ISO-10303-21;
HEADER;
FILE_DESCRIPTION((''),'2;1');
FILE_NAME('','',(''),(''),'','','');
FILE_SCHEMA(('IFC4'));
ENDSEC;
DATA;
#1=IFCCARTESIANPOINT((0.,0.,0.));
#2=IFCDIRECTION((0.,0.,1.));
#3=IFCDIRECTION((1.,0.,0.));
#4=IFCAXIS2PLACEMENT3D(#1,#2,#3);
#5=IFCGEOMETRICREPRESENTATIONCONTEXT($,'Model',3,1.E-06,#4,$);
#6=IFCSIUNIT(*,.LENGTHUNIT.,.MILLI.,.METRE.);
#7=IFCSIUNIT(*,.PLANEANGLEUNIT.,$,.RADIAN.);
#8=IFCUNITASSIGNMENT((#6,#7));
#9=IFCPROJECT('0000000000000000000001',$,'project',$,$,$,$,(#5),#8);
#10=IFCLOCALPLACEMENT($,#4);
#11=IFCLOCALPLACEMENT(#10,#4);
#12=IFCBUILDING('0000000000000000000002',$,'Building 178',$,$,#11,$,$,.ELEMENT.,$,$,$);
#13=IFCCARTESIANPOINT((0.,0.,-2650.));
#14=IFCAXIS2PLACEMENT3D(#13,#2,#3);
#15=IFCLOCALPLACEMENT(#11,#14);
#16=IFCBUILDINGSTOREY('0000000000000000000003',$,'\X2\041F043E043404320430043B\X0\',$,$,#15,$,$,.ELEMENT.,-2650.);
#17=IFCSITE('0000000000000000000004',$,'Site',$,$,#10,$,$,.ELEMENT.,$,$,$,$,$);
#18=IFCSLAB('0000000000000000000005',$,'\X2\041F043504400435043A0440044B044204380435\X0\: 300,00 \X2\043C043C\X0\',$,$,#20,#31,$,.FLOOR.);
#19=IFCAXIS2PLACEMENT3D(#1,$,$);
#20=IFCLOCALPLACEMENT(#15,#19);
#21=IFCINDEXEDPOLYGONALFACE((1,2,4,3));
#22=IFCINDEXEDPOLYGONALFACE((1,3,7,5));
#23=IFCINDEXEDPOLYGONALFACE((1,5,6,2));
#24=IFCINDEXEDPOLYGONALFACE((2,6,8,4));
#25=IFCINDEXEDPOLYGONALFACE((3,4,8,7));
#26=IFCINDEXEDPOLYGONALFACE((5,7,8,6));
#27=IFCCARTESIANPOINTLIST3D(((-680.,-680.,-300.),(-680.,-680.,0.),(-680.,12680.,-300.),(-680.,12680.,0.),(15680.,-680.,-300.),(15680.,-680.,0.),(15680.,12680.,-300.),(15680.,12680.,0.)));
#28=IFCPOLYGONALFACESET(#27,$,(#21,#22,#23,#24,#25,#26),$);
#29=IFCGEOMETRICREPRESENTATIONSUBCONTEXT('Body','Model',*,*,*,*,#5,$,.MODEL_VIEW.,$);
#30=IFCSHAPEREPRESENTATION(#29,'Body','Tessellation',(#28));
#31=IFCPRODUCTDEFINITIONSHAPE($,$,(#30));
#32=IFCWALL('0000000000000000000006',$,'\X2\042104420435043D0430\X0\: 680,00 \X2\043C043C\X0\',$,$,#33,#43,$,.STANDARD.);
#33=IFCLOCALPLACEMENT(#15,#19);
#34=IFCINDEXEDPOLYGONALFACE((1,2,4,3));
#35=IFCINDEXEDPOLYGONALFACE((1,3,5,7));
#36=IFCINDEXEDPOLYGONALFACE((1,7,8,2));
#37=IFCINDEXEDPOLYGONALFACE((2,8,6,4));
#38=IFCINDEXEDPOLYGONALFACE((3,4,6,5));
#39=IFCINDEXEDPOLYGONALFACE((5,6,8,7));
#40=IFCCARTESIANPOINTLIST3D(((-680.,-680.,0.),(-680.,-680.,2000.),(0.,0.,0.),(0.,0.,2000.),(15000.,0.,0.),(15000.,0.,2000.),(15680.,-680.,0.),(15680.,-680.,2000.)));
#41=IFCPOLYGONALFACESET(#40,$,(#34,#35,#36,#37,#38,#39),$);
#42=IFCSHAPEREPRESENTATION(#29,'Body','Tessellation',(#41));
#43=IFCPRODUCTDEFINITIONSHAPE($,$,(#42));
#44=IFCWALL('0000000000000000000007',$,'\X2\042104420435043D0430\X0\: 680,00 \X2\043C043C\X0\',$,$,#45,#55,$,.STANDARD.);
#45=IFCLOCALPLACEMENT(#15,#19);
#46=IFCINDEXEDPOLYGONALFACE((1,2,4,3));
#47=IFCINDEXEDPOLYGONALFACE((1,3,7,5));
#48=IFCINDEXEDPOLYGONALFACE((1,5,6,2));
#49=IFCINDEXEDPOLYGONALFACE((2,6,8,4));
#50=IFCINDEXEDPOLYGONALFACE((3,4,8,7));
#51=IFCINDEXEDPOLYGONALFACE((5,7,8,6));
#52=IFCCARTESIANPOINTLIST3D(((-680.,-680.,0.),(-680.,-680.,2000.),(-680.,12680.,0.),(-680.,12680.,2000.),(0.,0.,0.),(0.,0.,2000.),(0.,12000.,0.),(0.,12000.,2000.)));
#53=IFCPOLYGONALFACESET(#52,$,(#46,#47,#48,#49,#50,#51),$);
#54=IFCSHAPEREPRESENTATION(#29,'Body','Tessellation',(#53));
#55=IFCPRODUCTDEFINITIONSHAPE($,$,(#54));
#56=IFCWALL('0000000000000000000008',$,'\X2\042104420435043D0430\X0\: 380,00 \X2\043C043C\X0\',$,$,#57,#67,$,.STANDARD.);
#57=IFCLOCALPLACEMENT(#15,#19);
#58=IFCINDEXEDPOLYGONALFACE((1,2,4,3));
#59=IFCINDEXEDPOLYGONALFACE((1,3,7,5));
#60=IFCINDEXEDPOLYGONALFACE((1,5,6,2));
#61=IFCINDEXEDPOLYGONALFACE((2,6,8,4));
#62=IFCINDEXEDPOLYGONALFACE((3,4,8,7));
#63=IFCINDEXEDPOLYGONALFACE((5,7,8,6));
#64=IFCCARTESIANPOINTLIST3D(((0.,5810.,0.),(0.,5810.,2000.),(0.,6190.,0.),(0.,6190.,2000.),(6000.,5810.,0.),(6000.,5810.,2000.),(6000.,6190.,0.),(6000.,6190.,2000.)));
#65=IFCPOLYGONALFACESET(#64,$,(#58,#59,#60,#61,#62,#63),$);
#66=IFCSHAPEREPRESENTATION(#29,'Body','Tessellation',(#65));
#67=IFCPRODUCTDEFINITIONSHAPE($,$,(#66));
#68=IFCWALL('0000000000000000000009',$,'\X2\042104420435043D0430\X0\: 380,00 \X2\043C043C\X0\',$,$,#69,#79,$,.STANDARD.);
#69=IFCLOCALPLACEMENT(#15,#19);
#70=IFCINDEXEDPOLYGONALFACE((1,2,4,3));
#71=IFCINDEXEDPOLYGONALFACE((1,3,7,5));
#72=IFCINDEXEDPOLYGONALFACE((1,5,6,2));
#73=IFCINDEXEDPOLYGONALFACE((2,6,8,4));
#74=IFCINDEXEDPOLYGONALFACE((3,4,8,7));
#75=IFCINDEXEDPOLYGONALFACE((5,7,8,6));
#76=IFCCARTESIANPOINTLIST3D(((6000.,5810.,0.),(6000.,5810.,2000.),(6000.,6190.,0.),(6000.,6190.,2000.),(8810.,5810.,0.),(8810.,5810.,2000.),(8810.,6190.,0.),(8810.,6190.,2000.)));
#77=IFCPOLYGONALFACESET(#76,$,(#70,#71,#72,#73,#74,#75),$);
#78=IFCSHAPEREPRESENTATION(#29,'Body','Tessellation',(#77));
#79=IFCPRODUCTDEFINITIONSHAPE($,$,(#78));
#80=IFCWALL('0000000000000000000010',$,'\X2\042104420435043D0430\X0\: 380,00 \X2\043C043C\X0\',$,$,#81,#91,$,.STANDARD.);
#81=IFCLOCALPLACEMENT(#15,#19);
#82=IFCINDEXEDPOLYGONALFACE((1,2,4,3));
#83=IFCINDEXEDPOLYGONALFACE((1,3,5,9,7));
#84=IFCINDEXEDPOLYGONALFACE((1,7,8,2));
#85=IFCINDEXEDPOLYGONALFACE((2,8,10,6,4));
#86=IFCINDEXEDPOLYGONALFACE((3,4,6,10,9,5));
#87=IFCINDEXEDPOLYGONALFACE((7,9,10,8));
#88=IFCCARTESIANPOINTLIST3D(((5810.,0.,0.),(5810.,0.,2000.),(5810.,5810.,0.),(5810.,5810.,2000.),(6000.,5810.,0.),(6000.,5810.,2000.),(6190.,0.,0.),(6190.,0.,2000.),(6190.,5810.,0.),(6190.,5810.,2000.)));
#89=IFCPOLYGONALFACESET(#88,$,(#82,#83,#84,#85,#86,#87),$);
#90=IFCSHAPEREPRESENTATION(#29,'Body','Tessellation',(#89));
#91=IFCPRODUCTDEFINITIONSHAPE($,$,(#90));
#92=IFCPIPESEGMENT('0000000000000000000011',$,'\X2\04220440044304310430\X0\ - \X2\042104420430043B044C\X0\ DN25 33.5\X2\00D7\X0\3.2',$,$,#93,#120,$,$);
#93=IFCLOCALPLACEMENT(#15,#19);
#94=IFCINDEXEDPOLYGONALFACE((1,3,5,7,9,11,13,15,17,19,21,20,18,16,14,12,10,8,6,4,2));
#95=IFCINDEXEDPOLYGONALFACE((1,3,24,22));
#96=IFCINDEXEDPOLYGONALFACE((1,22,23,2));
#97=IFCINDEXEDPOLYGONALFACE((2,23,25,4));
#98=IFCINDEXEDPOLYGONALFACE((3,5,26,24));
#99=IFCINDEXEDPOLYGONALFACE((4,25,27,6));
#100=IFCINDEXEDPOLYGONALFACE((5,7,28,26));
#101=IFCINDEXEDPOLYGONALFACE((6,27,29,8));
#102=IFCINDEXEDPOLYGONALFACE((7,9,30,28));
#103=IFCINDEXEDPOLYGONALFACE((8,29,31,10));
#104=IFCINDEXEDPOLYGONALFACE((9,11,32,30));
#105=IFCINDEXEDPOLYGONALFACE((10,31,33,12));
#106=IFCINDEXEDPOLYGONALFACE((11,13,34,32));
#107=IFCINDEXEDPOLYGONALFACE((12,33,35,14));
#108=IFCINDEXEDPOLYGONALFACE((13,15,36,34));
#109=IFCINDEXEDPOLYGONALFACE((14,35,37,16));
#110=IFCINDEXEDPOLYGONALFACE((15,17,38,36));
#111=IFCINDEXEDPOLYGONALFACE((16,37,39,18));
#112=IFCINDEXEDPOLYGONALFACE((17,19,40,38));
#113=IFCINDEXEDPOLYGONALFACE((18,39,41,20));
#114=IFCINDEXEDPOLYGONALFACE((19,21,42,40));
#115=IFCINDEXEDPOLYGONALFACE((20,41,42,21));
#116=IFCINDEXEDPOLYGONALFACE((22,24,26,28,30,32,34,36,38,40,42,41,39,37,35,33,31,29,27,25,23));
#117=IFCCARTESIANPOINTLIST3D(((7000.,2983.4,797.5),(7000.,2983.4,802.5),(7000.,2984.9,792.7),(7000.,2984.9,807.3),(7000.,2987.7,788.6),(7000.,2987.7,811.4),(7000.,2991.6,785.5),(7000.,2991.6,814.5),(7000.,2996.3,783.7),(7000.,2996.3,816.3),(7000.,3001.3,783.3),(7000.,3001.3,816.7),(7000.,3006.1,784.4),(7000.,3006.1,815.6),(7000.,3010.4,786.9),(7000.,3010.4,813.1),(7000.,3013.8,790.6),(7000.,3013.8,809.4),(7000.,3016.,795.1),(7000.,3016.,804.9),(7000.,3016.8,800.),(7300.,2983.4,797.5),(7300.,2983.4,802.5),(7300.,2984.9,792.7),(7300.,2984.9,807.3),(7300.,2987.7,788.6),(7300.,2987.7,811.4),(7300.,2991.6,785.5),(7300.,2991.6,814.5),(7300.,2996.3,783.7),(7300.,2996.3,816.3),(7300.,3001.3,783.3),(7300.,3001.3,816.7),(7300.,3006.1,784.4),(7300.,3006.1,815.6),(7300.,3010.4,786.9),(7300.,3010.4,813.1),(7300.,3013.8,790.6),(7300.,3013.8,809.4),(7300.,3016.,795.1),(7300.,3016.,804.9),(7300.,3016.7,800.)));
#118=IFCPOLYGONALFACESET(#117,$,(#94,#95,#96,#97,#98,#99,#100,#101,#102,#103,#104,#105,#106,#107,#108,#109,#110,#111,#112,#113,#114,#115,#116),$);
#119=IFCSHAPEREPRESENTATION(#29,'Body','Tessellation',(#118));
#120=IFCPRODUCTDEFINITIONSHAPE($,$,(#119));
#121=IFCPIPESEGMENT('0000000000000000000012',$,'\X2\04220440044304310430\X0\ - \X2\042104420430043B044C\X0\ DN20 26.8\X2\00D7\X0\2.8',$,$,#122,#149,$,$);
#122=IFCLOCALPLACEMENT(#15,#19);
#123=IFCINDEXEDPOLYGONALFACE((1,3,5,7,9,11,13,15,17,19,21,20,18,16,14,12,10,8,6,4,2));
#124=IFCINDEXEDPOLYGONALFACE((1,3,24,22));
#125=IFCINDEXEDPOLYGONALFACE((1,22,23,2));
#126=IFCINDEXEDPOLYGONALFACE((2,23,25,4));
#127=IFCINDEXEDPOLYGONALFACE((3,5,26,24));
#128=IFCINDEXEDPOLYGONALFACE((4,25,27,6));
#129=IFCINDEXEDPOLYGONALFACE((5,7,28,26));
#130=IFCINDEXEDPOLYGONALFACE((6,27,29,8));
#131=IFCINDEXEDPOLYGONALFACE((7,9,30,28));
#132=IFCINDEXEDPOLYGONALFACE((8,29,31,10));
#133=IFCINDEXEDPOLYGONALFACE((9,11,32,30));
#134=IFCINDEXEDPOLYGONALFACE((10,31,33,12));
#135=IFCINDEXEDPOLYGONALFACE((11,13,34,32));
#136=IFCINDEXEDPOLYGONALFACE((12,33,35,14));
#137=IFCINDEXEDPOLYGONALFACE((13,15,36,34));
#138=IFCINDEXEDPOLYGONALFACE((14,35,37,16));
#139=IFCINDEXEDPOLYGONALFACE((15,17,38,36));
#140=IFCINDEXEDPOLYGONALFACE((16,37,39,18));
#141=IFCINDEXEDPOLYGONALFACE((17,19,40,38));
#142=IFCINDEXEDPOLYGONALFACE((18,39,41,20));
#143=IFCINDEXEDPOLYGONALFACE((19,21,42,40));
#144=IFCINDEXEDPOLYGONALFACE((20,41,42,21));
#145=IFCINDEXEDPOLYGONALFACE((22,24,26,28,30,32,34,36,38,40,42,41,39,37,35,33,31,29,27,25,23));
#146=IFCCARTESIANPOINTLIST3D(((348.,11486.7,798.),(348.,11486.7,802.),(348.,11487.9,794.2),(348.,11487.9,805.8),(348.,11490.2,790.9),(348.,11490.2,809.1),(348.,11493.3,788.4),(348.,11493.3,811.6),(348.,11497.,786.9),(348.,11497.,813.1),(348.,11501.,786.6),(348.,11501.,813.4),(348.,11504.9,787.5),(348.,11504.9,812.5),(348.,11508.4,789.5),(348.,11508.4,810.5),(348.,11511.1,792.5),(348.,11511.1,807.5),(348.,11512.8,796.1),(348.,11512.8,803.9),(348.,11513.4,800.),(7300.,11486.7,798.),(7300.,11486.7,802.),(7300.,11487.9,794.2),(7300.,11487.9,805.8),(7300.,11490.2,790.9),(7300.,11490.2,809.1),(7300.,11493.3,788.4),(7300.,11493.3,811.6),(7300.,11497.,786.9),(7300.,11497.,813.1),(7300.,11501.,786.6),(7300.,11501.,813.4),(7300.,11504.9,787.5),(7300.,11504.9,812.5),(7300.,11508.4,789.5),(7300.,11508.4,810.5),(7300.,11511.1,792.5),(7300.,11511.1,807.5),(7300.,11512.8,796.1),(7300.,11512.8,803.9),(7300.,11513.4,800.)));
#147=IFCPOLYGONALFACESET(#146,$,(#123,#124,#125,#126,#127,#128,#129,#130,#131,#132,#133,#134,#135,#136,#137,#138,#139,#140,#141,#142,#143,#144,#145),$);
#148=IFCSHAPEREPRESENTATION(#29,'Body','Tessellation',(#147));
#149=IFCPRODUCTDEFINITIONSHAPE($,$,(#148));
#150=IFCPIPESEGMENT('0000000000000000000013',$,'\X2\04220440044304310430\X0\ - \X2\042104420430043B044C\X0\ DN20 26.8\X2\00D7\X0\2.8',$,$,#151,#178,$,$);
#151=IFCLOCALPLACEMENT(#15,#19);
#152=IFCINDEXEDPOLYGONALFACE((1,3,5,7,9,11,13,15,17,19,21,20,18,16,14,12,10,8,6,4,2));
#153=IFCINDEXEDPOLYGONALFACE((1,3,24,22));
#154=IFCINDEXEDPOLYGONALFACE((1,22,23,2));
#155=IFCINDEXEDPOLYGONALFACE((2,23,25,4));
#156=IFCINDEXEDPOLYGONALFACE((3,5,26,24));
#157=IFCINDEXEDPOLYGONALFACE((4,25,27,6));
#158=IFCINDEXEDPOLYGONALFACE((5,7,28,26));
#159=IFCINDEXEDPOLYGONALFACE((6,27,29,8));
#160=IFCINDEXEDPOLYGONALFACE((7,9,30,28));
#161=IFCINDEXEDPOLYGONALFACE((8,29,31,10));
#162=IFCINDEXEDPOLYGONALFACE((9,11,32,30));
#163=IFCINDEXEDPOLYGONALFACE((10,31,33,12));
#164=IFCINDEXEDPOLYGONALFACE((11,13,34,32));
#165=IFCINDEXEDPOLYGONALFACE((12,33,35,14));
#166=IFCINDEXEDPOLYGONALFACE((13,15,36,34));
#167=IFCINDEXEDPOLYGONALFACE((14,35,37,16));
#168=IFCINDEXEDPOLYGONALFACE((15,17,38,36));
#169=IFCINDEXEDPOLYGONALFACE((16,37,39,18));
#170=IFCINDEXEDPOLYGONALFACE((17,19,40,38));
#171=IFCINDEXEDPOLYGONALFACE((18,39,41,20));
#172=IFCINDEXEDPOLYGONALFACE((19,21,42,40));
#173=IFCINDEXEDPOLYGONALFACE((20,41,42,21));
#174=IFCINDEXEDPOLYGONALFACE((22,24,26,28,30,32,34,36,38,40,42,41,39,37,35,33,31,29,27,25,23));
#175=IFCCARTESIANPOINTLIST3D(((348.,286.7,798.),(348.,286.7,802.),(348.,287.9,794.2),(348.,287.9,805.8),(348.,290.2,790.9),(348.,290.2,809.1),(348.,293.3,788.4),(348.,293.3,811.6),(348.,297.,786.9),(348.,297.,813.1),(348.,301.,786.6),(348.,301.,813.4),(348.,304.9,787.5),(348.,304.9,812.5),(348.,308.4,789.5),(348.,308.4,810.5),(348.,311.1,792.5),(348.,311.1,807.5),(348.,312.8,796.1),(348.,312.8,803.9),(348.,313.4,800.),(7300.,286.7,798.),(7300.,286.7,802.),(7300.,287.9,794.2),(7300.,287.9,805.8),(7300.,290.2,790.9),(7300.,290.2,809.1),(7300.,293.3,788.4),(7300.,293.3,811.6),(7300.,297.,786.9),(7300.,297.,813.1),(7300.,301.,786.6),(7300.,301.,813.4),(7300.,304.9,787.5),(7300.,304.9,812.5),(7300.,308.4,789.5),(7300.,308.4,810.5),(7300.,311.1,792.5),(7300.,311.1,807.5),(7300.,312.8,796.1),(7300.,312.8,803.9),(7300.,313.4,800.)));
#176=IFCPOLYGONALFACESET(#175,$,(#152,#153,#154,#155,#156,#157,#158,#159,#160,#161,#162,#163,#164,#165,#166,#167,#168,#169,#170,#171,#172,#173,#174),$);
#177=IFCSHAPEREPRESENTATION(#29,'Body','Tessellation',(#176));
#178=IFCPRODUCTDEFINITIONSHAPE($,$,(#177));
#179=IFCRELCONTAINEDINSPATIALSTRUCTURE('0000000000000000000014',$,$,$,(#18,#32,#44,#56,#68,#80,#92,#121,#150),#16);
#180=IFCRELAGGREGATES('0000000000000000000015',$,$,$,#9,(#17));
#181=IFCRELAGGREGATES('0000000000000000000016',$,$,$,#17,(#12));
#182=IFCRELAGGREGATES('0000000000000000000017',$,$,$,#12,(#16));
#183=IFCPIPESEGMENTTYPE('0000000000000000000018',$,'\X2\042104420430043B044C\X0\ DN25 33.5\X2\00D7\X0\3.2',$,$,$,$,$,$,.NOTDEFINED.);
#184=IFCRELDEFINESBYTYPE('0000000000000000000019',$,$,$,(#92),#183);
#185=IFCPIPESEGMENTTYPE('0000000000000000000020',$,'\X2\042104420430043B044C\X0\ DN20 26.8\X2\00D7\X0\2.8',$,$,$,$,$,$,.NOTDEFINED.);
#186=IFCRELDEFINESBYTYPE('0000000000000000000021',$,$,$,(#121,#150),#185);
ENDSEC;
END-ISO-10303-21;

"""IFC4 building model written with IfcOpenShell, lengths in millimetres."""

from ifc_helpers import new_model, entity, si_unit, frame, origin_with_axes, place, context, subcontext, project, spatial, line, indexed_curve, outline, extrude, source, transform, mapped, type_object, element, save


model = new_model("IFC4")

# Units and contexts
model_context = context("Model", 3, precision=1e-06, world=origin_with_axes())
body_context = subcontext(model_context, "Body", "Model", "MODEL_VIEW")
ifc_project = project(units=[si_unit("LENGTHUNIT", "METRE", prefix="MILLI"), si_unit("PLANEANGLEUNIT", "RADIAN")], contexts=[model_context])

# Site, building, storey
site_placement = place(None, origin_with_axes())
site = spatial("IfcSite", under=ifc_project, at=site_placement, Name="Site", CompositionType="ELEMENT")
building_placement = place(site_placement, origin_with_axes())
building = spatial("IfcBuilding", under=site, at=building_placement, Name="Building 178", CompositionType="ELEMENT")
storey_placement = place(building_placement, frame((0.0, 0.0, -2650.0), z_axis=(0.0, 0.0, 1.0), x_axis=(1.0, 0.0, 0.0)))
storey = spatial("IfcBuildingStorey", under=building, at=storey_placement, Name="Подвал", CompositionType="ELEMENT", Elevation=-2650.0)

# Slab
shared_shape_1 = source(origin_with_axes(), body_context, "Body", "SweptSolid", [
    extrude(outline(indexed_curve([(0.0, 0.0), (16360.0, 0.0), (16360.0, 13360.0), (0.0, 13360.0)], segments=[line(1, 2), line(2, 3), line(3, 4), line(4, 1)])), origin_with_axes(), (0.0, 0.0, 1.0), 300.0),
])
slab_placement = place(storey_placement, frame((-680.0, -680.0, -300.0), z_axis=(0.0, 0.0, 1.0), x_axis=(1.0, 0.0, 0.0)))
element("IfcSlab", 1, at=slab_placement, inside=storey, Name="Перекрытие: 300,00 мм", PredefinedType="FLOOR", context=body_context, shape_type="MappedRepresentation", body=[
    mapped(shared_shape_1, transform((0.0, 0.0, 0.0), x_axis=(1.0, 0.0, 0.0), y_axis=(0.0, 1.0, 0.0), z_axis=(0.0, 0.0, 1.0), scale=1.0)),
])

# Walls
shared_shape_2 = source(origin_with_axes(), body_context, "Body", "SweptSolid", [
    extrude(outline(indexed_curve([(-340.0, -340.0), (16020.0, -340.0), (15340.0, 340.0), (340.0, 340.0)], segments=[line(1, 2), line(2, 3), line(3, 4), line(4, 1)])), origin_with_axes(), (0.0, 0.0, 1.0), 2000.0),
])
wall_1_placement = place(storey_placement, frame((-340.0, -340.0, 0.0), z_axis=(0.0, 0.0, 1.0), x_axis=(1.0, 0.0, 0.0)))
element("IfcWall", 2, at=wall_1_placement, inside=storey, Name="Стена: 680,00 мм", PredefinedType="STANDARD", context=body_context, shape_type="MappedRepresentation", body=[
    mapped(shared_shape_2, transform((0.0, 0.0, 0.0), x_axis=(1.0, 0.0, 0.0), y_axis=(0.0, 1.0, 0.0), z_axis=(0.0, 0.0, 1.0), scale=1.0)),
])
shared_shape_3 = source(origin_with_axes(), body_context, "Body", "SweptSolid", [
    extrude(outline(indexed_curve([(-340.0, -340.0), (13020.0, -340.0), (12340.0, 340.0), (340.0, 340.0)], segments=[line(1, 2), line(2, 3), line(3, 4), line(4, 1)])), origin_with_axes(), (0.0, 0.0, 1.0), 2000.0),
])
wall_2_placement = place(storey_placement, frame((-340.0, 12340.0, 0.0), z_axis=(0.0, 0.0, 1.0), x_axis=(0.0, -1.0, 0.0)))
element("IfcWall", 3, at=wall_2_placement, inside=storey, Name="Стена: 680,00 мм", PredefinedType="STANDARD", context=body_context, shape_type="MappedRepresentation", body=[
    mapped(shared_shape_3, transform((0.0, 0.0, 0.0), x_axis=(1.0, 0.0, 0.0), y_axis=(0.0, 1.0, 0.0), z_axis=(0.0, 0.0, 1.0), scale=1.0)),
])
shared_shape_4 = source(origin_with_axes(), body_context, "Body", "SweptSolid", [
    extrude(outline(indexed_curve([(0.0, -190.0), (6000.0, -190.0), (6000.0, 190.0), (0.0, 190.0)], segments=[line(1, 2), line(2, 3), line(3, 4), line(4, 1)])), origin_with_axes(), (0.0, 0.0, 1.0), 2000.0),
])
wall_3_placement = place(storey_placement, frame((0.0, 6000.0, 0.0), z_axis=(0.0, 0.0, 1.0), x_axis=(1.0, 0.0, 0.0)))
element("IfcWall", 4, at=wall_3_placement, inside=storey, Name="Стена: 380,00 мм", PredefinedType="STANDARD", context=body_context, shape_type="MappedRepresentation", body=[
    mapped(shared_shape_4, transform((0.0, 0.0, 0.0), x_axis=(1.0, 0.0, 0.0), y_axis=(0.0, 1.0, 0.0), z_axis=(0.0, 0.0, 1.0), scale=1.0)),
])
shared_shape_5 = source(origin_with_axes(), body_context, "Body", "SweptSolid", [
    extrude(outline(indexed_curve([(0.0, -190.0), (2810.0, -190.0), (2810.0, 190.0), (0.0, 190.0)], segments=[line(1, 2), line(2, 3), line(3, 4), line(4, 1)])), origin_with_axes(), (0.0, 0.0, 1.0), 2000.0),
])
wall_4_placement = place(storey_placement, frame((6000.0, 6000.0, 0.0), z_axis=(0.0, 0.0, 1.0), x_axis=(1.0, 0.0, 0.0)))
element("IfcWall", 5, at=wall_4_placement, inside=storey, Name="Стена: 380,00 мм", PredefinedType="STANDARD", context=body_context, shape_type="MappedRepresentation", body=[
    mapped(shared_shape_5, transform((0.0, 0.0, 0.0), x_axis=(1.0, 0.0, 0.0), y_axis=(0.0, 1.0, 0.0), z_axis=(0.0, 0.0, 1.0), scale=1.0)),
])
shared_shape_6 = source(origin_with_axes(), body_context, "Body", "SweptSolid", [
    extrude(outline(indexed_curve([(0.0, -190.0), (5810.0, -190.0), (5810.0, 0.0), (5810.0, 190.0), (0.0, 190.0)], segments=[line(1, 2), line(2, 3), line(3, 4), line(4, 5), line(5, 1)])), origin_with_axes(), (0.0, 0.0, 1.0), 2000.0),
])
wall_5_placement = place(storey_placement, frame((6000.0, 0.0, 0.0), z_axis=(0.0, 0.0, 1.0), x_axis=(0.0, 1.0, 0.0)))
element("IfcWall", 6, at=wall_5_placement, inside=storey, Name="Стена: 380,00 мм", PredefinedType="STANDARD", context=body_context, shape_type="MappedRepresentation", body=[
    mapped(shared_shape_6, transform((0.0, 0.0, 0.0), x_axis=(1.0, 0.0, 0.0), y_axis=(0.0, 1.0, 0.0), z_axis=(0.0, 0.0, 1.0), scale=1.0)),
])

# Pipe segments
pipe_segment_type_1 = type_object("IfcPipeSegmentType", Name="Сталь DN25 33.5×3.2", PredefinedType="NOTDEFINED")
shared_shape_7 = source(origin_with_axes(), body_context, "Body", "AdvancedSweptSolid", [
    entity("IfcSweptDiskSolid", entity("IfcIndexedPolyCurve", entity("IfcCartesianPointList3D", [[0.0, 0.0, 0.0], [0.0, 0.0, -300.0]]), [entity("IfcLineIndex", [1, 2])]), 16.8),
])
pipe_segment_1_placement = place(storey_placement, frame((7000.0, 3000.0, 800.0), z_axis=(-1.0, 0.0, 0.0), x_axis=(0.0, -1.0, 0.0)))
element("IfcPipeSegment", 7, at=pipe_segment_1_placement, inside=storey, type_object=pipe_segment_type_1, Name="Труба - Сталь DN25 33.5×3.2", context=body_context, shape_type="MappedRepresentation", body=[
    mapped(shared_shape_7, transform((0.0, 0.0, 0.0), x_axis=(1.0, 0.0, 0.0), y_axis=(0.0, 1.0, 0.0), z_axis=(0.0, 0.0, 1.0), scale=1.0)),
])
pipe_segment_type_2 = type_object("IfcPipeSegmentType", Name="Сталь DN20 26.8×2.8", PredefinedType="NOTDEFINED")
shared_shape_8 = source(origin_with_axes(), body_context, "Body", "AdvancedSweptSolid", [
    entity("IfcSweptDiskSolid", entity("IfcIndexedPolyCurve", entity("IfcCartesianPointList3D", [[0.0, 0.0, 0.0], [0.0, 0.0, -6952.0]]), [entity("IfcLineIndex", [1, 2])]), 13.4),
])
for number, where, z_axis, x_axis, name in (
    (8, (348.0, 11500.0, 800.0), (-1.0, 0.0, 0.0), (0.0, -1.0, 0.0), "Труба - Сталь DN20 26.8×2.8"),
    (9, (348.0, 300.0, 800.0), (-1.0, 0.0, 0.0), (0.0, -1.0, 0.0), "Труба - Сталь DN20 26.8×2.8"),
):
    element("IfcPipeSegment", number, at=place(storey_placement, frame(where, z_axis=z_axis, x_axis=x_axis)), inside=storey, type_object=pipe_segment_type_2, Name=name, context=body_context, shape_type="MappedRepresentation", body=[
        mapped(shared_shape_8, transform((0.0, 0.0, 0.0), x_axis=(1.0, 0.0, 0.0), y_axis=(0.0, 1.0, 0.0), z_axis=(0.0, 0.0, 1.0), scale=1.0)),
    ])

save(model, "model.ifc")
